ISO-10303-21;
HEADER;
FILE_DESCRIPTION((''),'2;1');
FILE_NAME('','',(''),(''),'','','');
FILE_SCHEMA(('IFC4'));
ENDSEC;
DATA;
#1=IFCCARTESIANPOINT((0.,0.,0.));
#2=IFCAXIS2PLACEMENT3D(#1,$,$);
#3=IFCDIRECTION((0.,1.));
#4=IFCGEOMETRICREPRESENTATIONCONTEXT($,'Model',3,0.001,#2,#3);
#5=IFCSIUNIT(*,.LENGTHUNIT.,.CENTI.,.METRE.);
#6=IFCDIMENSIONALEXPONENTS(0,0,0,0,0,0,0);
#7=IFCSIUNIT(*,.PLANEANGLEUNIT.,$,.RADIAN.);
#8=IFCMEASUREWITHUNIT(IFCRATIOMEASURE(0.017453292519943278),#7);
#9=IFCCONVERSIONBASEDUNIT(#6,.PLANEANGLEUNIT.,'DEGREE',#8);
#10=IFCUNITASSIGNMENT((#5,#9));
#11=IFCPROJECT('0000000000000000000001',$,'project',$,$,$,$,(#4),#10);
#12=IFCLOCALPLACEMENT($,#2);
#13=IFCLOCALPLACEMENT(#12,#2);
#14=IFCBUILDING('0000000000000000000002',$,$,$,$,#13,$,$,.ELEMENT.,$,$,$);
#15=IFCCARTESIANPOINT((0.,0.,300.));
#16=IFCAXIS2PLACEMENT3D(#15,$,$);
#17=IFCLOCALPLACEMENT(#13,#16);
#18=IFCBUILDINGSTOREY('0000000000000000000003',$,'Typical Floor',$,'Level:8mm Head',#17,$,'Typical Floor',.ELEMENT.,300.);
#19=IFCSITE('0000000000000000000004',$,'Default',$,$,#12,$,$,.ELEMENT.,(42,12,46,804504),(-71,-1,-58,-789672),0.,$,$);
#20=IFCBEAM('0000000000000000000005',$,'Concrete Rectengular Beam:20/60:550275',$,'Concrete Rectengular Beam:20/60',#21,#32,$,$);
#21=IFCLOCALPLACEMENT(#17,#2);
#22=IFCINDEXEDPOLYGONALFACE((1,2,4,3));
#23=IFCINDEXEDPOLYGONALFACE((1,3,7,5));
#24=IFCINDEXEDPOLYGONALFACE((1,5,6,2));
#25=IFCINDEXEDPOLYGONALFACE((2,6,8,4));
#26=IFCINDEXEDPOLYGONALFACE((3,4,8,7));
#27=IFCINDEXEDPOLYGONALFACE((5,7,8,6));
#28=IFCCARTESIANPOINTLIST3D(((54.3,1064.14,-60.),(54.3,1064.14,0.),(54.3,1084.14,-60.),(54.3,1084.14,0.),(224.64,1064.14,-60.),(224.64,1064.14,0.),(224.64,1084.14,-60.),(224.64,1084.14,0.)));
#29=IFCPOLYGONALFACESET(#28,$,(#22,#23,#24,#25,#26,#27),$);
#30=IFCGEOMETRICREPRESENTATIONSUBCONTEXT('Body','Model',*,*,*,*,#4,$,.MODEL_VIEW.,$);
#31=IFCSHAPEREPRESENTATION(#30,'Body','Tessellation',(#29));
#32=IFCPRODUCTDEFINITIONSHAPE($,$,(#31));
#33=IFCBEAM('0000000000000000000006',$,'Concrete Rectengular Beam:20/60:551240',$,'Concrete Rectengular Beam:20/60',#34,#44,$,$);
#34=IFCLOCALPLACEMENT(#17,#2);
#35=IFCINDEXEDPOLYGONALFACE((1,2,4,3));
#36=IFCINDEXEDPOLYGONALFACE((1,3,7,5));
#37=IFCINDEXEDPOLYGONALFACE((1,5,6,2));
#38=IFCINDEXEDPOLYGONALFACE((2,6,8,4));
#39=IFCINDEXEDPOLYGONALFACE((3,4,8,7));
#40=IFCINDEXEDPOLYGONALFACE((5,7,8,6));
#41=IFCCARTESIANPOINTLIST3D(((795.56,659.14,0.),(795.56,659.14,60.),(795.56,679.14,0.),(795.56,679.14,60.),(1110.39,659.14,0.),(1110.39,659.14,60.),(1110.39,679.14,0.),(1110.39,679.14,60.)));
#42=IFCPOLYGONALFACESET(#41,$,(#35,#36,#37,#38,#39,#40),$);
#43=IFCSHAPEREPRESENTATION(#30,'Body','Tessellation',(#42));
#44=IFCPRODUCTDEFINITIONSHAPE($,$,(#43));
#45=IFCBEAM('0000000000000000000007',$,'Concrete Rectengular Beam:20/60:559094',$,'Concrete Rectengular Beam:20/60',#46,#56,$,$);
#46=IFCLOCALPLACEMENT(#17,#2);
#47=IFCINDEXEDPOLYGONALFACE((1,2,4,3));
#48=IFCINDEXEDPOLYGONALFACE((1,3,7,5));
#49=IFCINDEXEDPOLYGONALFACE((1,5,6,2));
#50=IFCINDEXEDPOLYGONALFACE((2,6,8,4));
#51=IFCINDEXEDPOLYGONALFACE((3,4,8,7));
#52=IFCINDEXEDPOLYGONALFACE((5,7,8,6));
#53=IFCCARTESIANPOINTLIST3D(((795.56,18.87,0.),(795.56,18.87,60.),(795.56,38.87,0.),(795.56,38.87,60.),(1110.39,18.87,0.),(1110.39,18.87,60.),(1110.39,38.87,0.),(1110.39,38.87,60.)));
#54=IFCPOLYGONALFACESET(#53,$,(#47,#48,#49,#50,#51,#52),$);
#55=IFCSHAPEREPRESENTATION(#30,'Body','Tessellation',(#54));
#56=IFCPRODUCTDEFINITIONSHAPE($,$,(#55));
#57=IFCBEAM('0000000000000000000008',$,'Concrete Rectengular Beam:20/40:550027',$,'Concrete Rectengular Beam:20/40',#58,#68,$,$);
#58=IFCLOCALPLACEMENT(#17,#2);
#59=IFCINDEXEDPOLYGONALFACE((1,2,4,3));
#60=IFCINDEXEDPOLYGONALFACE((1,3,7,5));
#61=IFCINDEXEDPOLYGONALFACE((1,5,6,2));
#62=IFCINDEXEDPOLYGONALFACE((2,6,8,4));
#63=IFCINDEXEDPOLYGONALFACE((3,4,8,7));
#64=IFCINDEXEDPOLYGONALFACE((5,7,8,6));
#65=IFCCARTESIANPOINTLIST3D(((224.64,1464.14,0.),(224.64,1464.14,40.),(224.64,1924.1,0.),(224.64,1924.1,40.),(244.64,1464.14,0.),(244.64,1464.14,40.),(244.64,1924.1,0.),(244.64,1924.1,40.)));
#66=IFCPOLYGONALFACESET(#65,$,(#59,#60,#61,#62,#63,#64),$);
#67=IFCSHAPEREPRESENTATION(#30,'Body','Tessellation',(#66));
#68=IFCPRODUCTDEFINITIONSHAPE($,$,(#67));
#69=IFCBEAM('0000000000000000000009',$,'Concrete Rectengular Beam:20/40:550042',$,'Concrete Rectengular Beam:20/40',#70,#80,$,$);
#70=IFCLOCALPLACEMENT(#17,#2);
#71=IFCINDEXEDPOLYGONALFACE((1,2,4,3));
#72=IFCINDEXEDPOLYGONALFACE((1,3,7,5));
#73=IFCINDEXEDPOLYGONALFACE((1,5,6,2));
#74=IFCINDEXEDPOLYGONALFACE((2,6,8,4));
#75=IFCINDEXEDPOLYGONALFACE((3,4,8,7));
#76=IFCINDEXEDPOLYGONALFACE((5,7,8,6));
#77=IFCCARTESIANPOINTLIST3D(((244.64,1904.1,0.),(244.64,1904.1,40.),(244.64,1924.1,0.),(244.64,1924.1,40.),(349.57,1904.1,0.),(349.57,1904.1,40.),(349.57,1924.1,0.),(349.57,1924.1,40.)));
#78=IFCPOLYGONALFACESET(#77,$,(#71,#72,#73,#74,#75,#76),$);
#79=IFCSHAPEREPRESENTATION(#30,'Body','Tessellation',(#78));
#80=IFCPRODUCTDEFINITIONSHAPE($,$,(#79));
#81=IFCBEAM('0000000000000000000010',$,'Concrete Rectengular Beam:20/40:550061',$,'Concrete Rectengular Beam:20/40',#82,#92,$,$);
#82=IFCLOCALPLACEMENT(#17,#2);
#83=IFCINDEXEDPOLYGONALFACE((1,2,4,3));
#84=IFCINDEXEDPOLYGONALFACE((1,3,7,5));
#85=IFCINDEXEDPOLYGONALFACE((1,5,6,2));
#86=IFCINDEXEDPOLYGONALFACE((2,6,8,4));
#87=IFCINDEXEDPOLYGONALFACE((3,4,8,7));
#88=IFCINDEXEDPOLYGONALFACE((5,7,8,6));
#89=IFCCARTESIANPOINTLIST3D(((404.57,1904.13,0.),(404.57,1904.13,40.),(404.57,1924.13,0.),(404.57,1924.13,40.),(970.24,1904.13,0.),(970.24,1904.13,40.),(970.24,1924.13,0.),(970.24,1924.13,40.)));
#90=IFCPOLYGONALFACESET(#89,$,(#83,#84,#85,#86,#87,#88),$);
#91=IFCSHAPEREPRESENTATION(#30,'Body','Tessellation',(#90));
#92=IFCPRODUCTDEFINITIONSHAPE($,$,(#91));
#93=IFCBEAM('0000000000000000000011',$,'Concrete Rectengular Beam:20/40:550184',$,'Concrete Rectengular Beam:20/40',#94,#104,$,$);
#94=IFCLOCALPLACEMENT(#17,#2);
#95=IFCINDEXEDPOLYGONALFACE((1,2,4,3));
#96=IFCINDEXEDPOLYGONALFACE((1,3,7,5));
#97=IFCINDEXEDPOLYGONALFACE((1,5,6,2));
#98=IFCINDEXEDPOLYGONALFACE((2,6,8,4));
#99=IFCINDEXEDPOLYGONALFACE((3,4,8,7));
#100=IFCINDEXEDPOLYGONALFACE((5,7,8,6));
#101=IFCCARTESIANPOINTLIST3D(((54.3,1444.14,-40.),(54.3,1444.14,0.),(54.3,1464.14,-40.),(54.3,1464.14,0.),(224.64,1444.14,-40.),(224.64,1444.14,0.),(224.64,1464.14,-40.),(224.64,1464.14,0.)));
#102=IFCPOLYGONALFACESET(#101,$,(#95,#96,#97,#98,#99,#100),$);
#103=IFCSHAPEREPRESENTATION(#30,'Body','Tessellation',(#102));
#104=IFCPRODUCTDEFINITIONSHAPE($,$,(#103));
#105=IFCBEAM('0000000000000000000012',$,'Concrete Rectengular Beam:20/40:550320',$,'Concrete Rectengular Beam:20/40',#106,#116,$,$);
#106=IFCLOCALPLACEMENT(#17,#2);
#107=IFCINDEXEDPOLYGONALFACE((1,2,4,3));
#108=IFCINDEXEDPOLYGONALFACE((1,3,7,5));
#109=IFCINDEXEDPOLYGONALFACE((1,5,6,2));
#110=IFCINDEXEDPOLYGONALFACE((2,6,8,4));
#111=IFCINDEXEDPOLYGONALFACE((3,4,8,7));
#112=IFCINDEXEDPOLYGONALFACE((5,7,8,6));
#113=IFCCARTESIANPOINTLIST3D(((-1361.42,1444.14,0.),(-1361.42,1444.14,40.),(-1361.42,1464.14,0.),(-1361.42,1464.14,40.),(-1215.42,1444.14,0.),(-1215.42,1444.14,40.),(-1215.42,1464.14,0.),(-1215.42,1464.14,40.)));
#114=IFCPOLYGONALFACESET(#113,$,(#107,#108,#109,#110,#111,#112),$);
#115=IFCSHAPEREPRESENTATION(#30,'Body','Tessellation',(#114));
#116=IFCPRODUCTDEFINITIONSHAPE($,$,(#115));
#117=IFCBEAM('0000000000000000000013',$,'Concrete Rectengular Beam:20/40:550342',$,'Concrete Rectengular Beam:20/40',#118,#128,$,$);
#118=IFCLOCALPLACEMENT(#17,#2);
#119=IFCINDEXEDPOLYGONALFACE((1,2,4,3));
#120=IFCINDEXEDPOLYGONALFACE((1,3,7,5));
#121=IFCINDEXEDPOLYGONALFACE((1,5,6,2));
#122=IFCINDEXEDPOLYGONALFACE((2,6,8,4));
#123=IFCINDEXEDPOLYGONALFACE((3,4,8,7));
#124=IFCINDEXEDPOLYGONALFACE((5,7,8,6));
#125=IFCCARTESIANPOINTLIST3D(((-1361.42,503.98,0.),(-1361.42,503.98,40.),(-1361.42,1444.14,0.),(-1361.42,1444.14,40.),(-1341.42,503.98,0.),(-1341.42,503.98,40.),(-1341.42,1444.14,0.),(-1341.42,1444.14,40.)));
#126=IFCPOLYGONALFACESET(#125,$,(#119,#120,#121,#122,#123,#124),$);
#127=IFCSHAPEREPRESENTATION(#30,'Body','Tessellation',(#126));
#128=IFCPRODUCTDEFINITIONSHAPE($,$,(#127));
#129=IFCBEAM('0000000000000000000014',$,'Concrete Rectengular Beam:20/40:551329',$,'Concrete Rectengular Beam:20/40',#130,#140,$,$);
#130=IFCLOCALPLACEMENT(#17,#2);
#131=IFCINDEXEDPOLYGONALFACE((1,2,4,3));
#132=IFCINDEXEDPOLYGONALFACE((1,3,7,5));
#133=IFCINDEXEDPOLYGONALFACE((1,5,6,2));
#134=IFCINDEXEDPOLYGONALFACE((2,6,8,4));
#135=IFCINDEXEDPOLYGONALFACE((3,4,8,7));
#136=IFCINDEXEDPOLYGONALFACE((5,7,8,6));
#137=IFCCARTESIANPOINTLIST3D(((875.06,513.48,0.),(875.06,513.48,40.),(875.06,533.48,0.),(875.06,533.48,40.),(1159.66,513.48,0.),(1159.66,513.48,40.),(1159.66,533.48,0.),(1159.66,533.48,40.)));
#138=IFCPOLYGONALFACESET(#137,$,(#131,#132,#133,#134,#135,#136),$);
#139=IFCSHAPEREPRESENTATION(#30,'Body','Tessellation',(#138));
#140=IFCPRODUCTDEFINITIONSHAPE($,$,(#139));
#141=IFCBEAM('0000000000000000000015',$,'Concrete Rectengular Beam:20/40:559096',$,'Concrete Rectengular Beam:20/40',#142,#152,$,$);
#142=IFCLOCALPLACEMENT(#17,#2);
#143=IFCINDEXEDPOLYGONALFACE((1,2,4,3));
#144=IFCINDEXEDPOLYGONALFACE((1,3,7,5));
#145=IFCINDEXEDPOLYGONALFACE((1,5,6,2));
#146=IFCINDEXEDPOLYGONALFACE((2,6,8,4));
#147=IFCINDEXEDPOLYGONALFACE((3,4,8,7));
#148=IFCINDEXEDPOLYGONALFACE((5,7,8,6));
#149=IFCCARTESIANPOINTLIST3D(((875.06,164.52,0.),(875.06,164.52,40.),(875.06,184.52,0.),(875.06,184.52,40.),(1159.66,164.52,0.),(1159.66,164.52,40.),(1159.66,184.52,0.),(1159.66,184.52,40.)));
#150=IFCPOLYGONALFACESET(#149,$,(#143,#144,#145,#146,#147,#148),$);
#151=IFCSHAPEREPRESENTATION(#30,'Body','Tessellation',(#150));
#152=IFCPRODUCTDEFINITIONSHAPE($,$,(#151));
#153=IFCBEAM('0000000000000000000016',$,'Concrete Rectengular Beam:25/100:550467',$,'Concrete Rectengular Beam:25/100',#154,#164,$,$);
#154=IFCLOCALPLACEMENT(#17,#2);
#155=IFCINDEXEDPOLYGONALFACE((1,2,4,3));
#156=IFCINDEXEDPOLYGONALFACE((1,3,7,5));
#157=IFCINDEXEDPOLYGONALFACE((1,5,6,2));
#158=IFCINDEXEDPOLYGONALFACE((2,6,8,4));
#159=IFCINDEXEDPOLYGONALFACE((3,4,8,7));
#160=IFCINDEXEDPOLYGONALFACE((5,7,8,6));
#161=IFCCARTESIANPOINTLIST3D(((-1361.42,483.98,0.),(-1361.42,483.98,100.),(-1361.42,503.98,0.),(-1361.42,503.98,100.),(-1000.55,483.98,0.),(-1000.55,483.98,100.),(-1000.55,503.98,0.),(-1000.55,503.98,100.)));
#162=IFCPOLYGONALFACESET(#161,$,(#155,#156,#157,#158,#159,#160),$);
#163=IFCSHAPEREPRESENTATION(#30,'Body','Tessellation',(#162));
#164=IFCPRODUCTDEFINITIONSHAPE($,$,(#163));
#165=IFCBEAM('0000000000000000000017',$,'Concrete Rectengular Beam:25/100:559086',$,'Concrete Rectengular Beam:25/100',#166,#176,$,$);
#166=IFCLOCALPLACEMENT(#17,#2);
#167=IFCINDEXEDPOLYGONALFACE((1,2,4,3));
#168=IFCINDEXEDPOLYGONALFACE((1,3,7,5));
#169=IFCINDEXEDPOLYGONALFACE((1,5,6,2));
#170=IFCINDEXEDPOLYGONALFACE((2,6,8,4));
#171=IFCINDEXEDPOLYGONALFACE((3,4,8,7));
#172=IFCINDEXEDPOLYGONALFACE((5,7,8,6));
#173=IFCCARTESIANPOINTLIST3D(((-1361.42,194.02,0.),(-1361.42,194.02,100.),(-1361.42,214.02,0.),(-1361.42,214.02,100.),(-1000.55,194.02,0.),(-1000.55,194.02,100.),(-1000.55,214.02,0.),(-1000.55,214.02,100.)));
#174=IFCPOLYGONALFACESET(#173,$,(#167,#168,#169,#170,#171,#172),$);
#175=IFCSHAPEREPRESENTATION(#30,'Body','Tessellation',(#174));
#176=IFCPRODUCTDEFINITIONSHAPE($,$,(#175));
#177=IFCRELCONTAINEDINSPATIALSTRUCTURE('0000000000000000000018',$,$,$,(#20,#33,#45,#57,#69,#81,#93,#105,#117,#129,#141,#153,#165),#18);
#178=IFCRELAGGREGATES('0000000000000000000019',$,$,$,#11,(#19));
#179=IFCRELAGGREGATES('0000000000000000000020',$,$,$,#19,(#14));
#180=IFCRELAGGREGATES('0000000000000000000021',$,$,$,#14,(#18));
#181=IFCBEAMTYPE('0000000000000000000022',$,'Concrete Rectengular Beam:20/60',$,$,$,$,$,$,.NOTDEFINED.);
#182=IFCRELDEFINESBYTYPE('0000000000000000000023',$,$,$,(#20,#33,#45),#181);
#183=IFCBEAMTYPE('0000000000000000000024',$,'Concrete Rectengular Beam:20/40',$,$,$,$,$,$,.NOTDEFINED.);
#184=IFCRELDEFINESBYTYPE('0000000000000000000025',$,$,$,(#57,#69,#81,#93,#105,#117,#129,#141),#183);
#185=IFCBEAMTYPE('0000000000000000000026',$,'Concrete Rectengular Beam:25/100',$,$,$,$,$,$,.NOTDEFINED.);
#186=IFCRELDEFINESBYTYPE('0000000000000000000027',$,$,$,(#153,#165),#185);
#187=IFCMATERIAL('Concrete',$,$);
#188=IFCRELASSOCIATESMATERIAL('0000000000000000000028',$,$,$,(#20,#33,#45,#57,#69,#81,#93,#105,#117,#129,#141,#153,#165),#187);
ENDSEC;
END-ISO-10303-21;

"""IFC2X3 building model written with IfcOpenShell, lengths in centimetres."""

from ifc_helpers import new_model, entity, si_unit, converted_unit, direction, frame, frame_2d, origin, place, context, subcontext, project, spatial, rectangle, extrude, material, type_object, element, save


model = new_model("IFC2X3")

# Units and contexts
model_context = context("Model", 3, precision=0.001, world=origin(), true_north=direction((0.0, 1.0)))
body_context = subcontext(model_context, "Body", "Model", "MODEL_VIEW")
ifc_project = project(units=[si_unit("LENGTHUNIT", "METRE", prefix="CENTI"), converted_unit("PLANEANGLEUNIT", "DEGREE", entity("IfcRatioMeasure", 0.017453292519943278), si_unit("PLANEANGLEUNIT", "RADIAN"), dimensions=[0, 0, 0, 0, 0, 0, 0])], contexts=[model_context])

# Site, building, storey
site_placement = place(None, origin())
site = spatial("IfcSite", under=ifc_project, at=site_placement, Name="Default", CompositionType="ELEMENT", RefLatitude=(42, 12, 46, 804504), RefLongitude=(-71, -1, -58, -789672), RefElevation=0.0)
building_placement = place(site_placement, origin())
building = spatial("IfcBuilding", under=site, at=building_placement, CompositionType="ELEMENT")
storey_placement = place(building_placement, frame((0.0, 0.0, 300.0)))
storey = spatial("IfcBuildingStorey", under=building, at=storey_placement, Name="Typical Floor", ObjectType="Level:8mm Head", LongName="Typical Floor", CompositionType="ELEMENT", Elevation=300.0)

# Beams
ifc_material = material(Name="Concrete")
beam_type_1 = type_object("IfcBeamType", Name="Concrete Rectengular Beam:20/60", PredefinedType="NOTDEFINED")
beam_1_placement = place(storey_placement, frame((234.64, 1074.14, 0.0), z_axis=(0.0, 0.0, 1.0), x_axis=(-1.0, 0.0, 0.0)))
element("IfcBeam", 1, at=beam_1_placement, inside=storey, type_object=beam_type_1, material=ifc_material, Name="Concrete Rectengular Beam:20/60:550275", ObjectType="Concrete Rectengular Beam:20/60", context=body_context, shape_type="SweptSolid", body=[
    extrude(rectangle(XDim=60.0, YDim=20.0, at=frame_2d((0.0, 0.0), x_axis=(1.0, 0.0))), frame((10.0, 0.0, -30.0), z_axis=(1.0, 0.0, 0.0), x_axis=(0.0, 0.0, -1.0)), (0.0, 0.0, 1.0), 170.35),
])
beam_2_placement = place(storey_placement, frame((795.56, 669.14, 0.0)))
element("IfcBeam", 2, at=beam_2_placement, inside=storey, type_object=beam_type_1, material=ifc_material, Name="Concrete Rectengular Beam:20/60:551240", ObjectType="Concrete Rectengular Beam:20/60", context=body_context, shape_type="SweptSolid", body=[
    extrude(rectangle(XDim=60.0, YDim=20.0, at=frame_2d((0.0, 0.0), x_axis=(1.0, 0.0))), frame((0.0, 0.0, 30.0), z_axis=(1.0, 0.0, 0.0), x_axis=(0.0, 0.0, -1.0)), (0.0, 0.0, 1.0), 314.83),
])
beam_3_placement = place(storey_placement, frame((795.56, 28.87, 0.0)))
element("IfcBeam", 3, at=beam_3_placement, inside=storey, type_object=beam_type_1, material=ifc_material, Name="Concrete Rectengular Beam:20/60:559094", ObjectType="Concrete Rectengular Beam:20/60", context=body_context, shape_type="SweptSolid", body=[
    extrude(rectangle(XDim=60.0, YDim=20.0, at=frame_2d((0.0, 0.0), x_axis=(1.0, 0.0))), frame((0.0, 0.0, 30.0), z_axis=(1.0, 0.0, 0.0), x_axis=(0.0, 0.0, -1.0)), (0.0, 0.0, 1.0), 314.83),
])
beam_type_2 = type_object("IfcBeamType", Name="Concrete Rectengular Beam:20/40", PredefinedType="NOTDEFINED")
beam_4_placement = place(storey_placement, frame((234.64, 1464.14, 0.0), z_axis=(0.0, 0.0, 1.0), x_axis=(0.0, 1.0, 0.0)))
element("IfcBeam", 4, at=beam_4_placement, inside=storey, type_object=beam_type_2, material=ifc_material, Name="Concrete Rectengular Beam:20/40:550027", ObjectType="Concrete Rectengular Beam:20/40", context=body_context, shape_type="SweptSolid", body=[
    extrude(rectangle(XDim=40.0, YDim=20.0, at=frame_2d((0.0, 0.0), x_axis=(1.0, 0.0))), frame((0.0, 0.0, 20.0), z_axis=(1.0, 0.0, 0.0), x_axis=(0.0, 0.0, -1.0)), (0.0, 0.0, 1.0), 459.96),
])
beam_5_placement = place(storey_placement, frame((234.64, 1914.1, 0.0)))
element("IfcBeam", 5, at=beam_5_placement, inside=storey, type_object=beam_type_2, material=ifc_material, Name="Concrete Rectengular Beam:20/40:550042", ObjectType="Concrete Rectengular Beam:20/40", context=body_context, shape_type="SweptSolid", body=[
    extrude(rectangle(XDim=40.0, YDim=20.0, at=frame_2d((0.0, 0.0), x_axis=(1.0, 0.0))), frame((10.0, 0.0, 20.0), z_axis=(1.0, 0.0, 0.0), x_axis=(0.0, 0.0, -1.0)), (0.0, 0.0, 1.0), 104.93),
])
beam_6_placement = place(storey_placement, frame((404.57, 1914.13, 0.0)))
element("IfcBeam", 6, at=beam_6_placement, inside=storey, type_object=beam_type_2, material=ifc_material, Name="Concrete Rectengular Beam:20/40:550061", ObjectType="Concrete Rectengular Beam:20/40", context=body_context, shape_type="SweptSolid", body=[
    extrude(rectangle(XDim=40.0, YDim=20.0, at=frame_2d((0.0, 0.0), x_axis=(1.0, 0.0))), frame((0.0, 0.0, 20.0), z_axis=(1.0, 0.0, 0.0), x_axis=(0.0, 0.0, -1.0)), (0.0, 0.0, 1.0), 565.67),
])
beam_7_placement = place(storey_placement, frame((234.64, 1454.14, 0.0), z_axis=(0.0, 0.0, 1.0), x_axis=(-1.0, 0.0, 0.0)))
element("IfcBeam", 7, at=beam_7_placement, inside=storey, type_object=beam_type_2, material=ifc_material, Name="Concrete Rectengular Beam:20/40:550184", ObjectType="Concrete Rectengular Beam:20/40", context=body_context, shape_type="SweptSolid", body=[
    extrude(rectangle(XDim=40.0, YDim=20.0, at=frame_2d((0.0, 0.0), x_axis=(1.0, 0.0))), frame((10.0, 0.0, -20.0), z_axis=(1.0, 0.0, 0.0), x_axis=(0.0, 0.0, -1.0)), (0.0, 0.0, 1.0), 170.35),
])
beam_8_placement = place(storey_placement, frame((-1215.42, 1454.14, 0.0), z_axis=(0.0, 0.0, 1.0), x_axis=(-1.0, 0.0, 0.0)))
element("IfcBeam", 8, at=beam_8_placement, inside=storey, type_object=beam_type_2, material=ifc_material, Name="Concrete Rectengular Beam:20/40:550320", ObjectType="Concrete Rectengular Beam:20/40", context=body_context, shape_type="SweptSolid", body=[
    extrude(rectangle(XDim=40.0, YDim=20.0, at=frame_2d((0.0, 0.0), x_axis=(1.0, 0.0))), frame((0.0, 0.0, 20.0), z_axis=(1.0, 0.0, 0.0), x_axis=(0.0, 0.0, -1.0)), (0.0, 0.0, 1.0), 146.0),
])
beam_9_placement = place(storey_placement, frame((-1351.42, 1454.14, 0.0), z_axis=(0.0, 0.0, 1.0), x_axis=(0.0, -1.0, 0.0)))
element("IfcBeam", 9, at=beam_9_placement, inside=storey, type_object=beam_type_2, material=ifc_material, Name="Concrete Rectengular Beam:20/40:550342", ObjectType="Concrete Rectengular Beam:20/40", context=body_context, shape_type="SweptSolid", body=[
    extrude(rectangle(XDim=40.0, YDim=20.0, at=frame_2d((0.0, 0.0), x_axis=(1.0, 0.0))), frame((10.0, 0.0, 20.0), z_axis=(1.0, 0.0, 0.0), x_axis=(0.0, 0.0, -1.0)), (0.0, 0.0, 1.0), 940.16),
])
beam_10_placement = place(storey_placement, frame((1159.66, 523.48, 0.0), z_axis=(0.0, 0.0, 1.0), x_axis=(-1.0, 0.0, 0.0)))
element("IfcBeam", 10, at=beam_10_placement, inside=storey, type_object=beam_type_2, material=ifc_material, Name="Concrete Rectengular Beam:20/40:551329", ObjectType="Concrete Rectengular Beam:20/40", context=body_context, shape_type="SweptSolid", body=[
    extrude(rectangle(XDim=40.0, YDim=20.0, at=frame_2d((0.0, 0.0), x_axis=(1.0, 0.0))), frame((0.0, 0.0, 20.0), z_axis=(1.0, 0.0, 0.0), x_axis=(0.0, 0.0, -1.0)), (0.0, 0.0, 1.0), 284.6),
])
beam_11_placement = place(storey_placement, frame((1159.66, 174.52, 0.0), z_axis=(0.0, 0.0, 1.0), x_axis=(-1.0, 0.0, 0.0)))
element("IfcBeam", 11, at=beam_11_placement, inside=storey, type_object=beam_type_2, material=ifc_material, Name="Concrete Rectengular Beam:20/40:559096", ObjectType="Concrete Rectengular Beam:20/40", context=body_context, shape_type="SweptSolid", body=[
    extrude(rectangle(XDim=40.0, YDim=20.0, at=frame_2d((0.0, 0.0), x_axis=(1.0, 0.0))), frame((0.0, 0.0, 20.0), z_axis=(1.0, 0.0, 0.0), x_axis=(0.0, 0.0, -1.0)), (0.0, 0.0, 1.0), 284.6),
])
beam_type_3 = type_object("IfcBeamType", Name="Concrete Rectengular Beam:25/100", PredefinedType="NOTDEFINED")
beam_12_placement = place(storey_placement, frame((-1000.55, 493.98, 0.0), z_axis=(0.0, 0.0, 1.0), x_axis=(-1.0, 0.0, 0.0)))
element("IfcBeam", 12, at=beam_12_placement, inside=storey, type_object=beam_type_3, material=ifc_material, Name="Concrete Rectengular Beam:25/100:550467", ObjectType="Concrete Rectengular Beam:25/100", context=body_context, shape_type="SweptSolid", body=[
    extrude(rectangle(XDim=100.0, YDim=20.0, at=frame_2d((0.0, 0.0), x_axis=(1.0, 0.0))), frame((0.0, 0.0, 50.0), z_axis=(1.0, 0.0, 0.0), x_axis=(0.0, 0.0, -1.0)), (0.0, 0.0, 1.0), 360.87),
])
beam_13_placement = place(storey_placement, frame((-1000.55, 204.02, 0.0), z_axis=(0.0, 0.0, 1.0), x_axis=(-1.0, 0.0, 0.0)))
element("IfcBeam", 13, at=beam_13_placement, inside=storey, type_object=beam_type_3, material=ifc_material, Name="Concrete Rectengular Beam:25/100:559086", ObjectType="Concrete Rectengular Beam:25/100", context=body_context, shape_type="SweptSolid", body=[
    extrude(rectangle(XDim=100.0, YDim=20.0, at=frame_2d((0.0, 0.0), x_axis=(1.0, 0.0))), frame((0.0, 0.0, 50.0), z_axis=(1.0, 0.0, 0.0), x_axis=(0.0, 0.0, -1.0)), (0.0, 0.0, 1.0), 360.87),
])

save(model, "model.ifc")
